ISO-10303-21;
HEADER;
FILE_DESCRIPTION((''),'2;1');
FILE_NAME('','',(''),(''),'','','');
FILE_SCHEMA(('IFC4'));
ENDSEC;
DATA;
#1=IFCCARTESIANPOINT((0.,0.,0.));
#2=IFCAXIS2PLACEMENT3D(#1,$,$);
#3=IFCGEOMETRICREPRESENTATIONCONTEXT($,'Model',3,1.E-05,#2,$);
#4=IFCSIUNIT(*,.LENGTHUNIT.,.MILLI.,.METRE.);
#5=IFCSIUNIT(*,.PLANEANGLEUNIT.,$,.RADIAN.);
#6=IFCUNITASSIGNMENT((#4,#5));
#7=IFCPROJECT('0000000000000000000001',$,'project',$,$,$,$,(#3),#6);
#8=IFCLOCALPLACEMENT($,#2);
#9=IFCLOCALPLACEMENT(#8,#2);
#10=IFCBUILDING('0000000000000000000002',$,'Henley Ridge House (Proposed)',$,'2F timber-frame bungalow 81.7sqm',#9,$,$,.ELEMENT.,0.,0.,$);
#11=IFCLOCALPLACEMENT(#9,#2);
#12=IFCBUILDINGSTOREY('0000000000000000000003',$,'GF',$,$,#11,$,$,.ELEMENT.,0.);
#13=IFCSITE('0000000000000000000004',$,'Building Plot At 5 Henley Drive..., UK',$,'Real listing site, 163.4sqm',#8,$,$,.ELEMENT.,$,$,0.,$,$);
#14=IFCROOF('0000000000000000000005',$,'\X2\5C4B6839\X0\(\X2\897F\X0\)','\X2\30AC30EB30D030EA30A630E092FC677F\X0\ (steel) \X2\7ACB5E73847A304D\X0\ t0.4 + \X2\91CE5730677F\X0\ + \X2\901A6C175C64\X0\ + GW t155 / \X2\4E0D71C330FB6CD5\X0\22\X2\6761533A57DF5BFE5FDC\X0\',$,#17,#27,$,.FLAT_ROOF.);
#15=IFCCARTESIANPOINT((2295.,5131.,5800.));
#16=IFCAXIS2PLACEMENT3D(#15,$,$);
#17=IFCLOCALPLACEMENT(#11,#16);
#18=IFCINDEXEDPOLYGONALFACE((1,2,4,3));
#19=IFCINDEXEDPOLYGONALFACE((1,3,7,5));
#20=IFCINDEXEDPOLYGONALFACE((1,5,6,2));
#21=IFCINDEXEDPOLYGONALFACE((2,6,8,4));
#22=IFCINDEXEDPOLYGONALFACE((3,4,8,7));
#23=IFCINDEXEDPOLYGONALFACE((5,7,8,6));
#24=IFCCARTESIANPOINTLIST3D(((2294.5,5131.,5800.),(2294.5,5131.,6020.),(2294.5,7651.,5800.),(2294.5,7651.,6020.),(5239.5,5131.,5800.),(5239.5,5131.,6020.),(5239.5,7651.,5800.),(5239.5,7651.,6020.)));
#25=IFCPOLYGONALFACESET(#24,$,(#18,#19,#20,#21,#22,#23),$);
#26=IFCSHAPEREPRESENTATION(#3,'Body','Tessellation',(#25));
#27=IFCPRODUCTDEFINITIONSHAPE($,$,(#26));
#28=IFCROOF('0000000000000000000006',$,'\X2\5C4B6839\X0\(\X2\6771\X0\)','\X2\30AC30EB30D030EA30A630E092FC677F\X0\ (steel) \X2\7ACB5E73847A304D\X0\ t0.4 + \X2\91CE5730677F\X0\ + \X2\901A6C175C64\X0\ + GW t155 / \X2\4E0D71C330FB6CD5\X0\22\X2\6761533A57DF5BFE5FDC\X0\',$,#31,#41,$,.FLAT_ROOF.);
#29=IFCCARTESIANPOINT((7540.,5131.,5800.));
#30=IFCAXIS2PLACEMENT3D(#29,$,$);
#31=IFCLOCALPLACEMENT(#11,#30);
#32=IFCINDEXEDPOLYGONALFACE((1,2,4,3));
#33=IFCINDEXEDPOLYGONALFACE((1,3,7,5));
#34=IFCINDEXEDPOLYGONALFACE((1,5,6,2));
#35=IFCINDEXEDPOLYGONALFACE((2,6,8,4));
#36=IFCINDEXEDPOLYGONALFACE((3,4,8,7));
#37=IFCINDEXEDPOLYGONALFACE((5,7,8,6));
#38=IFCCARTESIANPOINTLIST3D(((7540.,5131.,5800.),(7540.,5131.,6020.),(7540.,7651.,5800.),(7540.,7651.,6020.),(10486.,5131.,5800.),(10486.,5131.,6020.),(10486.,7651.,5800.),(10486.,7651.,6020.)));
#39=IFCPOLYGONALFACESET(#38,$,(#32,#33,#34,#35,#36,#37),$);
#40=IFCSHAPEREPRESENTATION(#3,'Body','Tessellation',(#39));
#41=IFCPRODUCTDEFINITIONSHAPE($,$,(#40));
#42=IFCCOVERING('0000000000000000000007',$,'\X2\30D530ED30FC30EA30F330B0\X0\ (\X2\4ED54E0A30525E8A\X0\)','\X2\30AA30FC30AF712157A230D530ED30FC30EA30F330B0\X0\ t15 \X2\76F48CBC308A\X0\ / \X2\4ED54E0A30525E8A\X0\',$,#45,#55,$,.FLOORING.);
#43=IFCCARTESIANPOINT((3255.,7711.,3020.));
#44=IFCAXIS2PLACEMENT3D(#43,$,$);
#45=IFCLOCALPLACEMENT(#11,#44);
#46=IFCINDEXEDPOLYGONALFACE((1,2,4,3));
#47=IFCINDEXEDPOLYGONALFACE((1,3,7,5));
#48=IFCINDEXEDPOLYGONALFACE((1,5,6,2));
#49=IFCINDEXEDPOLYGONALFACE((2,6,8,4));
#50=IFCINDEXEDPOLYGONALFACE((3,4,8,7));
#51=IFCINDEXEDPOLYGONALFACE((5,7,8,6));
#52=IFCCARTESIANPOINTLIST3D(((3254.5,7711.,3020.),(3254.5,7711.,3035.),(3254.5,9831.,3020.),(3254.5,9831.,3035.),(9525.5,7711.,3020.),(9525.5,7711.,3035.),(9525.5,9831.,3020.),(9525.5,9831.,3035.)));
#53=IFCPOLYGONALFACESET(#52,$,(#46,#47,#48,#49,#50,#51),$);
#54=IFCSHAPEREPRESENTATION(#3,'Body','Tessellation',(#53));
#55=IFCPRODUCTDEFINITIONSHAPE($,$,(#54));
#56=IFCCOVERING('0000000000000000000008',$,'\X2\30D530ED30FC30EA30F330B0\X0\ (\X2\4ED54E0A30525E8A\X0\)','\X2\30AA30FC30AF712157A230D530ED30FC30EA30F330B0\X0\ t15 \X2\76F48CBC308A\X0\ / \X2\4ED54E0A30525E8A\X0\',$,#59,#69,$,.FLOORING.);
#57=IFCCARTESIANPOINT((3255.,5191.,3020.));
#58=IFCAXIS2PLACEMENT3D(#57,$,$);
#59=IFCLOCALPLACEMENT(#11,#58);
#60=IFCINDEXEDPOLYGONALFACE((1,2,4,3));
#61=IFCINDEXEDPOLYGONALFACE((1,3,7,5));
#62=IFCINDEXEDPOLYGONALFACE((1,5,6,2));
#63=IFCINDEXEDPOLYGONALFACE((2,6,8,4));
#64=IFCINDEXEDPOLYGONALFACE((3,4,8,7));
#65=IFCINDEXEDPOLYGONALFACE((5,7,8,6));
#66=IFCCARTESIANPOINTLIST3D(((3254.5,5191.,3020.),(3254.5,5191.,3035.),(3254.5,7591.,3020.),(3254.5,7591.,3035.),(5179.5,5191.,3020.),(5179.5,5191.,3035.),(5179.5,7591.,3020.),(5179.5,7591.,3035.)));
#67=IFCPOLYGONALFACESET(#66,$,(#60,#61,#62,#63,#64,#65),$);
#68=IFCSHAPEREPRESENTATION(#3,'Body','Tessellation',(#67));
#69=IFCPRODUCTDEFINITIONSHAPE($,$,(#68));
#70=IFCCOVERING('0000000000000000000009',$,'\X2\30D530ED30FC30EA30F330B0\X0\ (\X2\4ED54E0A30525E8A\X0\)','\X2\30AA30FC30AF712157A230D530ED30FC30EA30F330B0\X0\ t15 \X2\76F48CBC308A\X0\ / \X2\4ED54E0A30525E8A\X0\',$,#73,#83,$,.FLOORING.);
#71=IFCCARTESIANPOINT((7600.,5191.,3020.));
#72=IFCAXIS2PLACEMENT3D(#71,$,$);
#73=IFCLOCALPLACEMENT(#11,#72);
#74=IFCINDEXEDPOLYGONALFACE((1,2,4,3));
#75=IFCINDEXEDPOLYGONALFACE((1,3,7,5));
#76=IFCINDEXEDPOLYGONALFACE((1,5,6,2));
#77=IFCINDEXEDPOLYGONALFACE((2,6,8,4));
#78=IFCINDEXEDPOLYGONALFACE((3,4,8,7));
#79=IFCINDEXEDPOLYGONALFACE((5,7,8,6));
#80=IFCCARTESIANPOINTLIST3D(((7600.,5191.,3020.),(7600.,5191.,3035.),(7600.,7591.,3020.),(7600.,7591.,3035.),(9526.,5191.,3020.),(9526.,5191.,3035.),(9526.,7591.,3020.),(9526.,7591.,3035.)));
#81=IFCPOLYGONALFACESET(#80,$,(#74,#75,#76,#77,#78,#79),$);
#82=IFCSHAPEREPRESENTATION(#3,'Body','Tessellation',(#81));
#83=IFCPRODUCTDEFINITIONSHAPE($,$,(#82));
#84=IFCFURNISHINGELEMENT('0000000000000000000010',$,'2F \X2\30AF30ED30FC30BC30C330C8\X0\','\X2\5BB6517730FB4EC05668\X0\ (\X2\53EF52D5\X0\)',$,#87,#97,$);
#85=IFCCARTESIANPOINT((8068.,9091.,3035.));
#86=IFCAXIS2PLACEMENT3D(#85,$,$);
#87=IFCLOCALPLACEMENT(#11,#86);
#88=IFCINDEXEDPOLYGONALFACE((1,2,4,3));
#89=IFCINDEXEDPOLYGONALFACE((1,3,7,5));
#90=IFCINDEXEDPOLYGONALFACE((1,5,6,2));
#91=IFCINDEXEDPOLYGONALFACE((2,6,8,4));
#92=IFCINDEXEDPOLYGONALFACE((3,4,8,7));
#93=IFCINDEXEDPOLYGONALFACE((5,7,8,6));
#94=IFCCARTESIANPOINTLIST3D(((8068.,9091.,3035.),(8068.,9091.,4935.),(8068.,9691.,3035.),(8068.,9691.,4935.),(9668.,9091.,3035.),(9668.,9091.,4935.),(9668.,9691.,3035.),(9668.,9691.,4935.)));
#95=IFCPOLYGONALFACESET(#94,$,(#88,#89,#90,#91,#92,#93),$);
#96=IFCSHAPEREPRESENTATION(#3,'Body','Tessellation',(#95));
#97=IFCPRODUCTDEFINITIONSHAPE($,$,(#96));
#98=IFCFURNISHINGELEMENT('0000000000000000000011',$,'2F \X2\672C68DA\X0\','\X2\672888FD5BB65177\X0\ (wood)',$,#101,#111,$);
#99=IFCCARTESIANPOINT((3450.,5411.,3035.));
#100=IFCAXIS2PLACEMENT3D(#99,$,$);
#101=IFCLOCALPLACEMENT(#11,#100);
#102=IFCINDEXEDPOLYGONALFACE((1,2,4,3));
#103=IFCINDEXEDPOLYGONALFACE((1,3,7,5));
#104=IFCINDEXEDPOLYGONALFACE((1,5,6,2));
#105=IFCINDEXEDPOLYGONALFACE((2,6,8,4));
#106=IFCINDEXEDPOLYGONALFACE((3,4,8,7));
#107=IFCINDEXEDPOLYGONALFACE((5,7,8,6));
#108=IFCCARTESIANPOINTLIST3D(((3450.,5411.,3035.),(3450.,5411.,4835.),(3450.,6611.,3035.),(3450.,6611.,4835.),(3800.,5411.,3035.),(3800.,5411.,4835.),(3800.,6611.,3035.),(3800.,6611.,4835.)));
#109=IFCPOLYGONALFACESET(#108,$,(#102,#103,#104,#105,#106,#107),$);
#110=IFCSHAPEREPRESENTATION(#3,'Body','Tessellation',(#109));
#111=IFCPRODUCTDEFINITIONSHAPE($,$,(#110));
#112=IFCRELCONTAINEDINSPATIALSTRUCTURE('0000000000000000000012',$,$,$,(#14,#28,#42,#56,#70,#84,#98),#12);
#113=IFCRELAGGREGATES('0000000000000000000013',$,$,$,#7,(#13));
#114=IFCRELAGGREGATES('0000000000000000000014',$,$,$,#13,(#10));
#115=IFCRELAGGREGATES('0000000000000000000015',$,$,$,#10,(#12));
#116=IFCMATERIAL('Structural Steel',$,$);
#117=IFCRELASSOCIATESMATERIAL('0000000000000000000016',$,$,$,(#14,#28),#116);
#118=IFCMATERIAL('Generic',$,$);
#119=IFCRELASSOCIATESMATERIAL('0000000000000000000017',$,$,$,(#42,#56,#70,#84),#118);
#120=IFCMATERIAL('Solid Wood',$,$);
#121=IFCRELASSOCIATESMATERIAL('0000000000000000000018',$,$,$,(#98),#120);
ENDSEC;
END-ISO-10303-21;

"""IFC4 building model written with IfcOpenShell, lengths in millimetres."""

from ifc_helpers import new_model, si_unit, frame, frame_2d, origin, place, context, project, spatial, rectangle, extrude, material, element, save


model = new_model("IFC4")

# Units and contexts
model_context = context("Model", 3, precision=1e-05, world=origin())
ifc_project = project(units=[si_unit("LENGTHUNIT", "METRE", prefix="MILLI"), si_unit("PLANEANGLEUNIT", "RADIAN")], contexts=[model_context])

# Site, building, storey
site_placement = place(None, origin())
site = spatial("IfcSite", under=ifc_project, at=site_placement, Name="Building Plot At 5 Henley Drive..., UK", ObjectType="Real listing site, 163.4sqm", CompositionType="ELEMENT", RefElevation=0.0)
building_placement = place(site_placement, origin())
building = spatial("IfcBuilding", under=site, at=building_placement, Name="Henley Ridge House (Proposed)", ObjectType="2F timber-frame bungalow 81.7sqm", CompositionType="ELEMENT", ElevationOfRefHeight=0.0, ElevationOfTerrain=0.0)
storey_placement = place(building_placement, origin())
storey = spatial("IfcBuildingStorey", under=building, at=storey_placement, Name="GF", CompositionType="ELEMENT", Elevation=0.0)

# Shared definitions
ifc_material_1 = material(Name="Solid Wood")

# Roofs
ifc_material_2 = material(Name="Structural Steel")
roof_1_placement = place(storey_placement, frame((2295.0, 5131.0, 5800.0)))
element("IfcRoof", 1, at=roof_1_placement, inside=storey, material=ifc_material_2, Name="屋根(西)", Description="ガルバリウム鋼板 (steel) 立平葺き t0.4 + 野地板 + 通気層 + GW t155 / 不燃・法22条区域対応", PredefinedType="FLAT_ROOF", context=model_context, shape_type="SweptSolid", body=[
    extrude(rectangle(XDim=2945.0, YDim=2520.0, at=frame_2d((1472.0, 1260.0))), frame((2295.0, 5131.0, 5800.0)), (0.0, 0.0, 1.0), 220.0),
])
roof_2_placement = place(storey_placement, frame((7540.0, 5131.0, 5800.0)))
element("IfcRoof", 2, at=roof_2_placement, inside=storey, material=ifc_material_2, Name="屋根(東)", Description="ガルバリウム鋼板 (steel) 立平葺き t0.4 + 野地板 + 通気層 + GW t155 / 不燃・法22条区域対応", PredefinedType="FLAT_ROOF", context=model_context, shape_type="SweptSolid", body=[
    extrude(rectangle(XDim=2946.0, YDim=2520.0, at=frame_2d((1473.0, 1260.0))), frame((7540.0, 5131.0, 5800.0)), (0.0, 0.0, 1.0), 220.0),
])

# Coverings
ifc_material_3 = material(Name="Generic")
covering_1_placement = place(storey_placement, frame((3255.0, 7711.0, 3020.0)))
element("IfcCovering", 3, at=covering_1_placement, inside=storey, material=ifc_material_3, Name="フローリング (仕上げ床)", Description="オーク無垢フローリング t15 直貼り / 仕上げ床", PredefinedType="FLOORING", context=model_context, shape_type="SweptSolid", body=[
    extrude(rectangle(XDim=6271.0, YDim=2120.0, at=frame_2d((3135.0, 1060.0))), frame((3255.0, 7711.0, 3020.0)), (0.0, 0.0, 1.0), 15.0),
])
covering_2_placement = place(storey_placement, frame((3255.0, 5191.0, 3020.0)))
element("IfcCovering", 4, at=covering_2_placement, inside=storey, material=ifc_material_3, Name="フローリング (仕上げ床)", Description="オーク無垢フローリング t15 直貼り / 仕上げ床", PredefinedType="FLOORING", context=model_context, shape_type="SweptSolid", body=[
    extrude(rectangle(XDim=1925.0, YDim=2400.0, at=frame_2d((962.0, 1200.0))), frame((3255.0, 5191.0, 3020.0)), (0.0, 0.0, 1.0), 15.0),
])
covering_3_placement = place(storey_placement, frame((7600.0, 5191.0, 3020.0)))
element("IfcCovering", 5, at=covering_3_placement, inside=storey, material=ifc_material_3, Name="フローリング (仕上げ床)", Description="オーク無垢フローリング t15 直貼り / 仕上げ床", PredefinedType="FLOORING", context=model_context, shape_type="SweptSolid", body=[
    extrude(rectangle(XDim=1926.0, YDim=2400.0, at=frame_2d((963.0, 1200.0))), frame((7600.0, 5191.0, 3020.0)), (0.0, 0.0, 1.0), 15.0),
])

# Furnishing elements
furnishing_1_placement = place(storey_placement, frame((8068.0, 9091.0, 3035.0)))
element("IfcFurnishingElement", 6, at=furnishing_1_placement, inside=storey, material=ifc_material_3, Name="2F クローゼット", Description="家具・什器 (可動)", context=model_context, shape_type="SweptSolid", body=[
    extrude(rectangle(XDim=1600.0, YDim=600.0, at=frame_2d((800.0, 300.0))), frame((8068.0, 9091.0, 3035.0)), (0.0, 0.0, 1.0), 1900.0),
])
furnishing_2_placement = place(storey_placement, frame((3450.0, 5411.0, 3035.0)))
element("IfcFurnishingElement", 7, at=furnishing_2_placement, inside=storey, material=ifc_material_1, Name="2F 本棚", Description="木製家具 (wood)", context=model_context, shape_type="SweptSolid", body=[
    extrude(rectangle(XDim=350.0, YDim=1200.0, at=frame_2d((175.0, 600.0))), frame((3450.0, 5411.0, 3035.0)), (0.0, 0.0, 1.0), 1800.0),
])

save(model, "model.ifc")
